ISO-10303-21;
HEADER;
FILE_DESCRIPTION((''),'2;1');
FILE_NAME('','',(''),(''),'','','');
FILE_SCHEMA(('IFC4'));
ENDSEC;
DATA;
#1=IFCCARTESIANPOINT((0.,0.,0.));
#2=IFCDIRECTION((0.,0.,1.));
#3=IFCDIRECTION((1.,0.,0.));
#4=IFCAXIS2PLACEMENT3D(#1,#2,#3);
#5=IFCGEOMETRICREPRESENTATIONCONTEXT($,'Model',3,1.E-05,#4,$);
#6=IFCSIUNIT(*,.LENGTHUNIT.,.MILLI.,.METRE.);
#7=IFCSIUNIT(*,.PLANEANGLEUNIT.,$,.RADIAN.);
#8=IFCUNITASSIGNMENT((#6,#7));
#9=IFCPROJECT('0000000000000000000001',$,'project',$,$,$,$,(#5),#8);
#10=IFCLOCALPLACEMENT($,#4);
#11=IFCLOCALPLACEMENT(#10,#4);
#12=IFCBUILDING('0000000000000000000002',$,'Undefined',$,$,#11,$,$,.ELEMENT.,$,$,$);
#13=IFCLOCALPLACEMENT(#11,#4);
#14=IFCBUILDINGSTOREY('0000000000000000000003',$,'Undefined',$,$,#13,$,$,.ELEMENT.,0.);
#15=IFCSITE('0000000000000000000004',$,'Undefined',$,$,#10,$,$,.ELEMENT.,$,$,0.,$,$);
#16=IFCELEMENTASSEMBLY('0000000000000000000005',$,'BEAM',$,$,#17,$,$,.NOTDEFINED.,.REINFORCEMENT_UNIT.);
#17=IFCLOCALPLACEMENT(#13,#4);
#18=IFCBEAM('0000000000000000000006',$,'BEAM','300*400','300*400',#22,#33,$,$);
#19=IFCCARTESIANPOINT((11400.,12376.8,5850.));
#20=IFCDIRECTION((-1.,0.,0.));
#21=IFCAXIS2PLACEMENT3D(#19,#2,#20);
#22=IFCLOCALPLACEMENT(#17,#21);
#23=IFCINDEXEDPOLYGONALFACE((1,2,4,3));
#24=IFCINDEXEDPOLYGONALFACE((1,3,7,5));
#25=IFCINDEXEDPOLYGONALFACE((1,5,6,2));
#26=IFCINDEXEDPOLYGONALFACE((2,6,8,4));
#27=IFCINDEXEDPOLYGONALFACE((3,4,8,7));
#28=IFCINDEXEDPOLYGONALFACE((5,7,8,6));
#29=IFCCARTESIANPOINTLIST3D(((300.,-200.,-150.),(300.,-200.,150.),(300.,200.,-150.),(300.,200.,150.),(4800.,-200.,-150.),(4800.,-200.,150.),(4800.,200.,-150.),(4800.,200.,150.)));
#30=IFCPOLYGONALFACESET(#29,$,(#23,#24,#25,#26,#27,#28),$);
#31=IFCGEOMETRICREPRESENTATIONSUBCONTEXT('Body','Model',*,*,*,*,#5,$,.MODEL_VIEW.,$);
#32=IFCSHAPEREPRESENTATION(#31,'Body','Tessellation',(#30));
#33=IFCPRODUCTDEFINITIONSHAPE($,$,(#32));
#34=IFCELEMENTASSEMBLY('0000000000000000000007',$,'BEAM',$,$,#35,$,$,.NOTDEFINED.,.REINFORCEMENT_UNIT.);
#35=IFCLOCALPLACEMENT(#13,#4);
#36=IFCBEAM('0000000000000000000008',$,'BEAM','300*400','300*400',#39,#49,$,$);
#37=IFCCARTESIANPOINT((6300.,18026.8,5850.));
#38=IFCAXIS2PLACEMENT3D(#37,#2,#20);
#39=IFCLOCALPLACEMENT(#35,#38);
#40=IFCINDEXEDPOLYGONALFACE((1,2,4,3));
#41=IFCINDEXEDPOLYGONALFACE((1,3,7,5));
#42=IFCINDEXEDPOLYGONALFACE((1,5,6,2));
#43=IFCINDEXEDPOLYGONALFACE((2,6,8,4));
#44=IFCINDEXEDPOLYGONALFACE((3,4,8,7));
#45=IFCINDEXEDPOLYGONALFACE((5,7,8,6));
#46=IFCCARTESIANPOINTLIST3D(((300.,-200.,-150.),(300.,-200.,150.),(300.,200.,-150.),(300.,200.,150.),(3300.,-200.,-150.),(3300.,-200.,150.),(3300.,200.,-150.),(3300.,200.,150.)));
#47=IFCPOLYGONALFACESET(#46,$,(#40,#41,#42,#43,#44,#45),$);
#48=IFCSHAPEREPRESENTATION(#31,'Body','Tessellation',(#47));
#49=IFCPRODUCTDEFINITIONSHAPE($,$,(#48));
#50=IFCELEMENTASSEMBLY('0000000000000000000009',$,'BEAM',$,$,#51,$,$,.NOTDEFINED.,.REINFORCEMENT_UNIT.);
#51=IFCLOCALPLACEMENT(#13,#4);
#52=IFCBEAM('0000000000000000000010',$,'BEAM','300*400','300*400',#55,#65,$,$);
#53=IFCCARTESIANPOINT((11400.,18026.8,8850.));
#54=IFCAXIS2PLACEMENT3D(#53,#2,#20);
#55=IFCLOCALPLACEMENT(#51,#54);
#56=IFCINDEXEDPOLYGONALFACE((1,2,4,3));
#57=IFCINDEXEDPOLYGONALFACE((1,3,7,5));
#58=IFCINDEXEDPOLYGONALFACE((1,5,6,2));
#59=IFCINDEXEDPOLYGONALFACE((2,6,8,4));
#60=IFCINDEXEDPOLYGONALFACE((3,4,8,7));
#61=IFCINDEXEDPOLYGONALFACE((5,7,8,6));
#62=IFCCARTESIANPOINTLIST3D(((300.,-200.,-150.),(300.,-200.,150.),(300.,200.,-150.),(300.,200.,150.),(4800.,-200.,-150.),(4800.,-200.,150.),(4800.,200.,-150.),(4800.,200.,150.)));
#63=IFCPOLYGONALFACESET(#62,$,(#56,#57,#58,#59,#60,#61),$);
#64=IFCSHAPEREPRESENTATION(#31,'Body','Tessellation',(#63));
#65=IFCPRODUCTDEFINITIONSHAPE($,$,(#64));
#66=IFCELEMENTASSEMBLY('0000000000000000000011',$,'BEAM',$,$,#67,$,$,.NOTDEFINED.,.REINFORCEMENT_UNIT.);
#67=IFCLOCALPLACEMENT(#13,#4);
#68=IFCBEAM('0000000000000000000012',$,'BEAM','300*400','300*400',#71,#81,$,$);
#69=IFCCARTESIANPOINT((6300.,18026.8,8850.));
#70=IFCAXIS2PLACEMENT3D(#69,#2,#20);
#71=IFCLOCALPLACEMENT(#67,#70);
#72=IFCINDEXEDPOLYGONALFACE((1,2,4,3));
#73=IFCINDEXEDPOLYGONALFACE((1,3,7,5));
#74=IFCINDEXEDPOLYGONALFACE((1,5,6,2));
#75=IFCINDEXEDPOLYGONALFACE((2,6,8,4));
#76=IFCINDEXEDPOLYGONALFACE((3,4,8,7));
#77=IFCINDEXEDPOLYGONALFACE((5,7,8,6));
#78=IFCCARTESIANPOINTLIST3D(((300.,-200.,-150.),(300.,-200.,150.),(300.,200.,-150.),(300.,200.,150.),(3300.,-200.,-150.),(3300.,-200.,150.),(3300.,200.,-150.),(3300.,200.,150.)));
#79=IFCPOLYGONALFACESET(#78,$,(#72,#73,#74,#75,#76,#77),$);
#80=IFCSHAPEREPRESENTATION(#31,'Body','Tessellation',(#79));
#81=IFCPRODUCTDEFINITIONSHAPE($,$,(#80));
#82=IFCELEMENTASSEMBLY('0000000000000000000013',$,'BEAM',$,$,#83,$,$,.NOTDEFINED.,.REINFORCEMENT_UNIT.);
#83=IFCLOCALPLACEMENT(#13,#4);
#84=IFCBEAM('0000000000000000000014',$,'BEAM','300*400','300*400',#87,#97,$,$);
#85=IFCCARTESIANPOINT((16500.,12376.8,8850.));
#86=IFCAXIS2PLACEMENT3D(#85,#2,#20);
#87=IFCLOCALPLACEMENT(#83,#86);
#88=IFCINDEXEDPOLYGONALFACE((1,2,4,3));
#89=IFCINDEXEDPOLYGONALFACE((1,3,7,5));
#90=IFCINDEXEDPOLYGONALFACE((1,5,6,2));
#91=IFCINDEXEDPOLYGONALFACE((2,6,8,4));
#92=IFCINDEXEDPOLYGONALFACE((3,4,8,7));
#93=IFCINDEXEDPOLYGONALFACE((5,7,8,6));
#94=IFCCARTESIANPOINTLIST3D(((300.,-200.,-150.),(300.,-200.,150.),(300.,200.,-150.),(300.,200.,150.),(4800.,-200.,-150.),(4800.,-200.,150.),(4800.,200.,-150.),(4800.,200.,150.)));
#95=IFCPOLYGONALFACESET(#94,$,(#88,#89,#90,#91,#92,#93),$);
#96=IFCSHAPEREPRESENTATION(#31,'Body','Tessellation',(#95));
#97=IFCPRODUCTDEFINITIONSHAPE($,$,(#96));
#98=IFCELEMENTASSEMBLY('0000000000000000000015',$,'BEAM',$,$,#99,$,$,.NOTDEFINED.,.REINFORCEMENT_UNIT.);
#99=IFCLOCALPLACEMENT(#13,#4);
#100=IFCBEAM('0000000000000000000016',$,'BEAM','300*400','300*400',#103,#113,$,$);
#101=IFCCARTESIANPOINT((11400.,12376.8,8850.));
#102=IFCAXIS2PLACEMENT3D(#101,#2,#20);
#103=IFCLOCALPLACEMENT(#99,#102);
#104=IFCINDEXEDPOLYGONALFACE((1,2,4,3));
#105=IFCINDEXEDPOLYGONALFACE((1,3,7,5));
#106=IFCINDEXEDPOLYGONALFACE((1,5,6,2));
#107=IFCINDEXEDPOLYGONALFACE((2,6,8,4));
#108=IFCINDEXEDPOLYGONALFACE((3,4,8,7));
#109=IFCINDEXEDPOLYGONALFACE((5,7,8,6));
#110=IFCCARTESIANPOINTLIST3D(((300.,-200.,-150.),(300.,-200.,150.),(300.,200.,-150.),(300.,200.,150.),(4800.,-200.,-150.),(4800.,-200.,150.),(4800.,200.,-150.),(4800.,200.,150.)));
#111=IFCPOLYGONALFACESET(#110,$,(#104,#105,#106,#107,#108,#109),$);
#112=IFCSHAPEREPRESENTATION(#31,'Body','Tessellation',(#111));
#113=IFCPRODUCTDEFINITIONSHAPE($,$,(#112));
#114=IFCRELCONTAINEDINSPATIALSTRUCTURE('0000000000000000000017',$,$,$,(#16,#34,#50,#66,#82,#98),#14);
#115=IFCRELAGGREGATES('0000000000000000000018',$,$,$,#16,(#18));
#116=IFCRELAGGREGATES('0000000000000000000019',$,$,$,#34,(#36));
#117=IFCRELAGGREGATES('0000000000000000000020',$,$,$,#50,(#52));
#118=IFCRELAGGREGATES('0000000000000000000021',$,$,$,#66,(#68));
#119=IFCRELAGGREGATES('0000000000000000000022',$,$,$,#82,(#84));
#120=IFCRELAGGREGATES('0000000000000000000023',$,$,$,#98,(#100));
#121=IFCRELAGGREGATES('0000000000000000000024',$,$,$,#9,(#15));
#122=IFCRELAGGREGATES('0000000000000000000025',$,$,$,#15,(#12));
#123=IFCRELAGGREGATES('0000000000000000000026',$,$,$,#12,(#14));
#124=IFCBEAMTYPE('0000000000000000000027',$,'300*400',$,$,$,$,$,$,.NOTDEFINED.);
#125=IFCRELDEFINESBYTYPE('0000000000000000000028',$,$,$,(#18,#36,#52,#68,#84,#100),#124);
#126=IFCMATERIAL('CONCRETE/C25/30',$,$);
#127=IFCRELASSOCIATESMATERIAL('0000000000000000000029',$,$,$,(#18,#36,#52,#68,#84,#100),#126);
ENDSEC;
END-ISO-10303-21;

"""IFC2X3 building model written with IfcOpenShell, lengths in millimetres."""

from ifc_helpers import new_model, si_unit, frame, origin_with_axes, origin_2d_with_axis, place, context, subcontext, project, spatial, rectangle, extrude, material, type_object, element, aggregate, save


model = new_model("IFC2X3")

# Units and contexts
model_context = context("Model", 3, precision=1e-05, world=origin_with_axes())
body_context = subcontext(model_context, "Body", "Model", "MODEL_VIEW")
ifc_project = project(units=[si_unit("LENGTHUNIT", "METRE", prefix="MILLI"), si_unit("PLANEANGLEUNIT", "RADIAN")], contexts=[model_context])

# Site, building, storey
site_placement = place(None, origin_with_axes())
site = spatial("IfcSite", under=ifc_project, at=site_placement, Name="Undefined", CompositionType="ELEMENT", RefElevation=0.0)
building_placement = place(site_placement, origin_with_axes())
building = spatial("IfcBuilding", under=site, at=building_placement, Name="Undefined", CompositionType="ELEMENT")
storey_placement = place(building_placement, origin_with_axes())
storey = spatial("IfcBuildingStorey", under=building, at=storey_placement, Name="Undefined", CompositionType="ELEMENT", Elevation=0.0)

# Shared definitions
ifc_material = material(Name="CONCRETE/C25/30")

# Element assemblies, beams
beam_type_1 = type_object("IfcBeamType", Name="300*400", PredefinedType="NOTDEFINED")
assembly_1_placement = place(storey_placement, origin_with_axes())
assembly_1 = element("IfcElementAssembly", 1, at=assembly_1_placement, inside=storey, Name="BEAM", AssemblyPlace="NOTDEFINED", PredefinedType="REINFORCEMENT_UNIT")
beam_1_placement = place(assembly_1_placement, frame((11400.0, 12376.8, 5850.0), z_axis=(0.0, 0.0, 1.0), x_axis=(-1.0, 0.0, 0.0)))
beam_1 = element("IfcBeam", 2, at=beam_1_placement, type_object=beam_type_1, material=ifc_material, Name="BEAM", Description="300*400", ObjectType="300*400", context=body_context, shape_type="SweptSolid", body=[
    extrude(rectangle(XDim=400.0, YDim=300.0, at=origin_2d_with_axis()), frame((4800.0, 0.0, 0.0), z_axis=(-1.0, 0.0, 0.0), x_axis=(0.0, -1.0, 0.0)), (0.0, 0.0, 1.0), 4500.0),
])
aggregate(assembly_1, [beam_1])
assembly_2_placement = place(storey_placement, origin_with_axes())
assembly_2 = element("IfcElementAssembly", 3, at=assembly_2_placement, inside=storey, Name="BEAM", AssemblyPlace="NOTDEFINED", PredefinedType="REINFORCEMENT_UNIT")
beam_2_placement = place(assembly_2_placement, frame((6300.0, 18026.8, 5850.0), z_axis=(0.0, 0.0, 1.0), x_axis=(-1.0, 0.0, 0.0)))
beam_2 = element("IfcBeam", 4, at=beam_2_placement, type_object=beam_type_1, material=ifc_material, Name="BEAM", Description="300*400", ObjectType="300*400", context=body_context, shape_type="SweptSolid", body=[
    extrude(rectangle(XDim=400.0, YDim=300.0, at=origin_2d_with_axis()), frame((3300.0, 0.0, 0.0), z_axis=(-1.0, 0.0, 0.0), x_axis=(0.0, -1.0, 0.0)), (0.0, 0.0, 1.0), 3000.0),
])
aggregate(assembly_2, [beam_2])
assembly_3_placement = place(storey_placement, origin_with_axes())
assembly_3 = element("IfcElementAssembly", 5, at=assembly_3_placement, inside=storey, Name="BEAM", AssemblyPlace="NOTDEFINED", PredefinedType="REINFORCEMENT_UNIT")
beam_3_placement = place(assembly_3_placement, frame((11400.0, 18026.8, 8850.0), z_axis=(0.0, 0.0, 1.0), x_axis=(-1.0, 0.0, 0.0)))
beam_3 = element("IfcBeam", 6, at=beam_3_placement, type_object=beam_type_1, material=ifc_material, Name="BEAM", Description="300*400", ObjectType="300*400", context=body_context, shape_type="SweptSolid", body=[
    extrude(rectangle(XDim=400.0, YDim=300.0, at=origin_2d_with_axis()), frame((4800.0, 0.0, 0.0), z_axis=(-1.0, 0.0, 0.0), x_axis=(0.0, -1.0, 0.0)), (0.0, 0.0, 1.0), 4500.0),
])
aggregate(assembly_3, [beam_3])
assembly_4_placement = place(storey_placement, origin_with_axes())
assembly_4 = element("IfcElementAssembly", 7, at=assembly_4_placement, inside=storey, Name="BEAM", AssemblyPlace="NOTDEFINED", PredefinedType="REINFORCEMENT_UNIT")
beam_4_placement = place(assembly_4_placement, frame((6300.0, 18026.8, 8850.0), z_axis=(0.0, 0.0, 1.0), x_axis=(-1.0, 0.0, 0.0)))
beam_4 = element("IfcBeam", 8, at=beam_4_placement, type_object=beam_type_1, material=ifc_material, Name="BEAM", Description="300*400", ObjectType="300*400", context=body_context, shape_type="SweptSolid", body=[
    extrude(rectangle(XDim=400.0, YDim=300.0, at=origin_2d_with_axis()), frame((3300.0, 0.0, 0.0), z_axis=(-1.0, 0.0, 0.0), x_axis=(0.0, -1.0, 0.0)), (0.0, 0.0, 1.0), 3000.0),
])
aggregate(assembly_4, [beam_4])
assembly_5_placement = place(storey_placement, origin_with_axes())
assembly_5 = element("IfcElementAssembly", 9, at=assembly_5_placement, inside=storey, Name="BEAM", AssemblyPlace="NOTDEFINED", PredefinedType="REINFORCEMENT_UNIT")
beam_5_placement = place(assembly_5_placement, frame((16500.0, 12376.8, 8850.0), z_axis=(0.0, 0.0, 1.0), x_axis=(-1.0, 0.0, 0.0)))
beam_5 = element("IfcBeam", 10, at=beam_5_placement, type_object=beam_type_1, material=ifc_material, Name="BEAM", Description="300*400", ObjectType="300*400", context=body_context, shape_type="SweptSolid", body=[
    extrude(rectangle(XDim=400.0, YDim=300.0, at=origin_2d_with_axis()), frame((4800.0, 0.0, 0.0), z_axis=(-1.0, 0.0, 0.0), x_axis=(0.0, -1.0, 0.0)), (0.0, 0.0, 1.0), 4500.0),
])
aggregate(assembly_5, [beam_5])
assembly_6_placement = place(storey_placement, origin_with_axes())
assembly_6 = element("IfcElementAssembly", 11, at=assembly_6_placement, inside=storey, Name="BEAM", AssemblyPlace="NOTDEFINED", PredefinedType="REINFORCEMENT_UNIT")
beam_6_placement = place(assembly_6_placement, frame((11400.0, 12376.8, 8850.0), z_axis=(0.0, 0.0, 1.0), x_axis=(-1.0, 0.0, 0.0)))
beam_6 = element("IfcBeam", 12, at=beam_6_placement, type_object=beam_type_1, material=ifc_material, Name="BEAM", Description="300*400", ObjectType="300*400", context=body_context, shape_type="SweptSolid", body=[
    extrude(rectangle(XDim=400.0, YDim=300.0, at=origin_2d_with_axis()), frame((4800.0, 0.0, 0.0), z_axis=(-1.0, 0.0, 0.0), x_axis=(0.0, -1.0, 0.0)), (0.0, 0.0, 1.0), 4500.0),
])
aggregate(assembly_6, [beam_6])

save(model, "model.ifc")
